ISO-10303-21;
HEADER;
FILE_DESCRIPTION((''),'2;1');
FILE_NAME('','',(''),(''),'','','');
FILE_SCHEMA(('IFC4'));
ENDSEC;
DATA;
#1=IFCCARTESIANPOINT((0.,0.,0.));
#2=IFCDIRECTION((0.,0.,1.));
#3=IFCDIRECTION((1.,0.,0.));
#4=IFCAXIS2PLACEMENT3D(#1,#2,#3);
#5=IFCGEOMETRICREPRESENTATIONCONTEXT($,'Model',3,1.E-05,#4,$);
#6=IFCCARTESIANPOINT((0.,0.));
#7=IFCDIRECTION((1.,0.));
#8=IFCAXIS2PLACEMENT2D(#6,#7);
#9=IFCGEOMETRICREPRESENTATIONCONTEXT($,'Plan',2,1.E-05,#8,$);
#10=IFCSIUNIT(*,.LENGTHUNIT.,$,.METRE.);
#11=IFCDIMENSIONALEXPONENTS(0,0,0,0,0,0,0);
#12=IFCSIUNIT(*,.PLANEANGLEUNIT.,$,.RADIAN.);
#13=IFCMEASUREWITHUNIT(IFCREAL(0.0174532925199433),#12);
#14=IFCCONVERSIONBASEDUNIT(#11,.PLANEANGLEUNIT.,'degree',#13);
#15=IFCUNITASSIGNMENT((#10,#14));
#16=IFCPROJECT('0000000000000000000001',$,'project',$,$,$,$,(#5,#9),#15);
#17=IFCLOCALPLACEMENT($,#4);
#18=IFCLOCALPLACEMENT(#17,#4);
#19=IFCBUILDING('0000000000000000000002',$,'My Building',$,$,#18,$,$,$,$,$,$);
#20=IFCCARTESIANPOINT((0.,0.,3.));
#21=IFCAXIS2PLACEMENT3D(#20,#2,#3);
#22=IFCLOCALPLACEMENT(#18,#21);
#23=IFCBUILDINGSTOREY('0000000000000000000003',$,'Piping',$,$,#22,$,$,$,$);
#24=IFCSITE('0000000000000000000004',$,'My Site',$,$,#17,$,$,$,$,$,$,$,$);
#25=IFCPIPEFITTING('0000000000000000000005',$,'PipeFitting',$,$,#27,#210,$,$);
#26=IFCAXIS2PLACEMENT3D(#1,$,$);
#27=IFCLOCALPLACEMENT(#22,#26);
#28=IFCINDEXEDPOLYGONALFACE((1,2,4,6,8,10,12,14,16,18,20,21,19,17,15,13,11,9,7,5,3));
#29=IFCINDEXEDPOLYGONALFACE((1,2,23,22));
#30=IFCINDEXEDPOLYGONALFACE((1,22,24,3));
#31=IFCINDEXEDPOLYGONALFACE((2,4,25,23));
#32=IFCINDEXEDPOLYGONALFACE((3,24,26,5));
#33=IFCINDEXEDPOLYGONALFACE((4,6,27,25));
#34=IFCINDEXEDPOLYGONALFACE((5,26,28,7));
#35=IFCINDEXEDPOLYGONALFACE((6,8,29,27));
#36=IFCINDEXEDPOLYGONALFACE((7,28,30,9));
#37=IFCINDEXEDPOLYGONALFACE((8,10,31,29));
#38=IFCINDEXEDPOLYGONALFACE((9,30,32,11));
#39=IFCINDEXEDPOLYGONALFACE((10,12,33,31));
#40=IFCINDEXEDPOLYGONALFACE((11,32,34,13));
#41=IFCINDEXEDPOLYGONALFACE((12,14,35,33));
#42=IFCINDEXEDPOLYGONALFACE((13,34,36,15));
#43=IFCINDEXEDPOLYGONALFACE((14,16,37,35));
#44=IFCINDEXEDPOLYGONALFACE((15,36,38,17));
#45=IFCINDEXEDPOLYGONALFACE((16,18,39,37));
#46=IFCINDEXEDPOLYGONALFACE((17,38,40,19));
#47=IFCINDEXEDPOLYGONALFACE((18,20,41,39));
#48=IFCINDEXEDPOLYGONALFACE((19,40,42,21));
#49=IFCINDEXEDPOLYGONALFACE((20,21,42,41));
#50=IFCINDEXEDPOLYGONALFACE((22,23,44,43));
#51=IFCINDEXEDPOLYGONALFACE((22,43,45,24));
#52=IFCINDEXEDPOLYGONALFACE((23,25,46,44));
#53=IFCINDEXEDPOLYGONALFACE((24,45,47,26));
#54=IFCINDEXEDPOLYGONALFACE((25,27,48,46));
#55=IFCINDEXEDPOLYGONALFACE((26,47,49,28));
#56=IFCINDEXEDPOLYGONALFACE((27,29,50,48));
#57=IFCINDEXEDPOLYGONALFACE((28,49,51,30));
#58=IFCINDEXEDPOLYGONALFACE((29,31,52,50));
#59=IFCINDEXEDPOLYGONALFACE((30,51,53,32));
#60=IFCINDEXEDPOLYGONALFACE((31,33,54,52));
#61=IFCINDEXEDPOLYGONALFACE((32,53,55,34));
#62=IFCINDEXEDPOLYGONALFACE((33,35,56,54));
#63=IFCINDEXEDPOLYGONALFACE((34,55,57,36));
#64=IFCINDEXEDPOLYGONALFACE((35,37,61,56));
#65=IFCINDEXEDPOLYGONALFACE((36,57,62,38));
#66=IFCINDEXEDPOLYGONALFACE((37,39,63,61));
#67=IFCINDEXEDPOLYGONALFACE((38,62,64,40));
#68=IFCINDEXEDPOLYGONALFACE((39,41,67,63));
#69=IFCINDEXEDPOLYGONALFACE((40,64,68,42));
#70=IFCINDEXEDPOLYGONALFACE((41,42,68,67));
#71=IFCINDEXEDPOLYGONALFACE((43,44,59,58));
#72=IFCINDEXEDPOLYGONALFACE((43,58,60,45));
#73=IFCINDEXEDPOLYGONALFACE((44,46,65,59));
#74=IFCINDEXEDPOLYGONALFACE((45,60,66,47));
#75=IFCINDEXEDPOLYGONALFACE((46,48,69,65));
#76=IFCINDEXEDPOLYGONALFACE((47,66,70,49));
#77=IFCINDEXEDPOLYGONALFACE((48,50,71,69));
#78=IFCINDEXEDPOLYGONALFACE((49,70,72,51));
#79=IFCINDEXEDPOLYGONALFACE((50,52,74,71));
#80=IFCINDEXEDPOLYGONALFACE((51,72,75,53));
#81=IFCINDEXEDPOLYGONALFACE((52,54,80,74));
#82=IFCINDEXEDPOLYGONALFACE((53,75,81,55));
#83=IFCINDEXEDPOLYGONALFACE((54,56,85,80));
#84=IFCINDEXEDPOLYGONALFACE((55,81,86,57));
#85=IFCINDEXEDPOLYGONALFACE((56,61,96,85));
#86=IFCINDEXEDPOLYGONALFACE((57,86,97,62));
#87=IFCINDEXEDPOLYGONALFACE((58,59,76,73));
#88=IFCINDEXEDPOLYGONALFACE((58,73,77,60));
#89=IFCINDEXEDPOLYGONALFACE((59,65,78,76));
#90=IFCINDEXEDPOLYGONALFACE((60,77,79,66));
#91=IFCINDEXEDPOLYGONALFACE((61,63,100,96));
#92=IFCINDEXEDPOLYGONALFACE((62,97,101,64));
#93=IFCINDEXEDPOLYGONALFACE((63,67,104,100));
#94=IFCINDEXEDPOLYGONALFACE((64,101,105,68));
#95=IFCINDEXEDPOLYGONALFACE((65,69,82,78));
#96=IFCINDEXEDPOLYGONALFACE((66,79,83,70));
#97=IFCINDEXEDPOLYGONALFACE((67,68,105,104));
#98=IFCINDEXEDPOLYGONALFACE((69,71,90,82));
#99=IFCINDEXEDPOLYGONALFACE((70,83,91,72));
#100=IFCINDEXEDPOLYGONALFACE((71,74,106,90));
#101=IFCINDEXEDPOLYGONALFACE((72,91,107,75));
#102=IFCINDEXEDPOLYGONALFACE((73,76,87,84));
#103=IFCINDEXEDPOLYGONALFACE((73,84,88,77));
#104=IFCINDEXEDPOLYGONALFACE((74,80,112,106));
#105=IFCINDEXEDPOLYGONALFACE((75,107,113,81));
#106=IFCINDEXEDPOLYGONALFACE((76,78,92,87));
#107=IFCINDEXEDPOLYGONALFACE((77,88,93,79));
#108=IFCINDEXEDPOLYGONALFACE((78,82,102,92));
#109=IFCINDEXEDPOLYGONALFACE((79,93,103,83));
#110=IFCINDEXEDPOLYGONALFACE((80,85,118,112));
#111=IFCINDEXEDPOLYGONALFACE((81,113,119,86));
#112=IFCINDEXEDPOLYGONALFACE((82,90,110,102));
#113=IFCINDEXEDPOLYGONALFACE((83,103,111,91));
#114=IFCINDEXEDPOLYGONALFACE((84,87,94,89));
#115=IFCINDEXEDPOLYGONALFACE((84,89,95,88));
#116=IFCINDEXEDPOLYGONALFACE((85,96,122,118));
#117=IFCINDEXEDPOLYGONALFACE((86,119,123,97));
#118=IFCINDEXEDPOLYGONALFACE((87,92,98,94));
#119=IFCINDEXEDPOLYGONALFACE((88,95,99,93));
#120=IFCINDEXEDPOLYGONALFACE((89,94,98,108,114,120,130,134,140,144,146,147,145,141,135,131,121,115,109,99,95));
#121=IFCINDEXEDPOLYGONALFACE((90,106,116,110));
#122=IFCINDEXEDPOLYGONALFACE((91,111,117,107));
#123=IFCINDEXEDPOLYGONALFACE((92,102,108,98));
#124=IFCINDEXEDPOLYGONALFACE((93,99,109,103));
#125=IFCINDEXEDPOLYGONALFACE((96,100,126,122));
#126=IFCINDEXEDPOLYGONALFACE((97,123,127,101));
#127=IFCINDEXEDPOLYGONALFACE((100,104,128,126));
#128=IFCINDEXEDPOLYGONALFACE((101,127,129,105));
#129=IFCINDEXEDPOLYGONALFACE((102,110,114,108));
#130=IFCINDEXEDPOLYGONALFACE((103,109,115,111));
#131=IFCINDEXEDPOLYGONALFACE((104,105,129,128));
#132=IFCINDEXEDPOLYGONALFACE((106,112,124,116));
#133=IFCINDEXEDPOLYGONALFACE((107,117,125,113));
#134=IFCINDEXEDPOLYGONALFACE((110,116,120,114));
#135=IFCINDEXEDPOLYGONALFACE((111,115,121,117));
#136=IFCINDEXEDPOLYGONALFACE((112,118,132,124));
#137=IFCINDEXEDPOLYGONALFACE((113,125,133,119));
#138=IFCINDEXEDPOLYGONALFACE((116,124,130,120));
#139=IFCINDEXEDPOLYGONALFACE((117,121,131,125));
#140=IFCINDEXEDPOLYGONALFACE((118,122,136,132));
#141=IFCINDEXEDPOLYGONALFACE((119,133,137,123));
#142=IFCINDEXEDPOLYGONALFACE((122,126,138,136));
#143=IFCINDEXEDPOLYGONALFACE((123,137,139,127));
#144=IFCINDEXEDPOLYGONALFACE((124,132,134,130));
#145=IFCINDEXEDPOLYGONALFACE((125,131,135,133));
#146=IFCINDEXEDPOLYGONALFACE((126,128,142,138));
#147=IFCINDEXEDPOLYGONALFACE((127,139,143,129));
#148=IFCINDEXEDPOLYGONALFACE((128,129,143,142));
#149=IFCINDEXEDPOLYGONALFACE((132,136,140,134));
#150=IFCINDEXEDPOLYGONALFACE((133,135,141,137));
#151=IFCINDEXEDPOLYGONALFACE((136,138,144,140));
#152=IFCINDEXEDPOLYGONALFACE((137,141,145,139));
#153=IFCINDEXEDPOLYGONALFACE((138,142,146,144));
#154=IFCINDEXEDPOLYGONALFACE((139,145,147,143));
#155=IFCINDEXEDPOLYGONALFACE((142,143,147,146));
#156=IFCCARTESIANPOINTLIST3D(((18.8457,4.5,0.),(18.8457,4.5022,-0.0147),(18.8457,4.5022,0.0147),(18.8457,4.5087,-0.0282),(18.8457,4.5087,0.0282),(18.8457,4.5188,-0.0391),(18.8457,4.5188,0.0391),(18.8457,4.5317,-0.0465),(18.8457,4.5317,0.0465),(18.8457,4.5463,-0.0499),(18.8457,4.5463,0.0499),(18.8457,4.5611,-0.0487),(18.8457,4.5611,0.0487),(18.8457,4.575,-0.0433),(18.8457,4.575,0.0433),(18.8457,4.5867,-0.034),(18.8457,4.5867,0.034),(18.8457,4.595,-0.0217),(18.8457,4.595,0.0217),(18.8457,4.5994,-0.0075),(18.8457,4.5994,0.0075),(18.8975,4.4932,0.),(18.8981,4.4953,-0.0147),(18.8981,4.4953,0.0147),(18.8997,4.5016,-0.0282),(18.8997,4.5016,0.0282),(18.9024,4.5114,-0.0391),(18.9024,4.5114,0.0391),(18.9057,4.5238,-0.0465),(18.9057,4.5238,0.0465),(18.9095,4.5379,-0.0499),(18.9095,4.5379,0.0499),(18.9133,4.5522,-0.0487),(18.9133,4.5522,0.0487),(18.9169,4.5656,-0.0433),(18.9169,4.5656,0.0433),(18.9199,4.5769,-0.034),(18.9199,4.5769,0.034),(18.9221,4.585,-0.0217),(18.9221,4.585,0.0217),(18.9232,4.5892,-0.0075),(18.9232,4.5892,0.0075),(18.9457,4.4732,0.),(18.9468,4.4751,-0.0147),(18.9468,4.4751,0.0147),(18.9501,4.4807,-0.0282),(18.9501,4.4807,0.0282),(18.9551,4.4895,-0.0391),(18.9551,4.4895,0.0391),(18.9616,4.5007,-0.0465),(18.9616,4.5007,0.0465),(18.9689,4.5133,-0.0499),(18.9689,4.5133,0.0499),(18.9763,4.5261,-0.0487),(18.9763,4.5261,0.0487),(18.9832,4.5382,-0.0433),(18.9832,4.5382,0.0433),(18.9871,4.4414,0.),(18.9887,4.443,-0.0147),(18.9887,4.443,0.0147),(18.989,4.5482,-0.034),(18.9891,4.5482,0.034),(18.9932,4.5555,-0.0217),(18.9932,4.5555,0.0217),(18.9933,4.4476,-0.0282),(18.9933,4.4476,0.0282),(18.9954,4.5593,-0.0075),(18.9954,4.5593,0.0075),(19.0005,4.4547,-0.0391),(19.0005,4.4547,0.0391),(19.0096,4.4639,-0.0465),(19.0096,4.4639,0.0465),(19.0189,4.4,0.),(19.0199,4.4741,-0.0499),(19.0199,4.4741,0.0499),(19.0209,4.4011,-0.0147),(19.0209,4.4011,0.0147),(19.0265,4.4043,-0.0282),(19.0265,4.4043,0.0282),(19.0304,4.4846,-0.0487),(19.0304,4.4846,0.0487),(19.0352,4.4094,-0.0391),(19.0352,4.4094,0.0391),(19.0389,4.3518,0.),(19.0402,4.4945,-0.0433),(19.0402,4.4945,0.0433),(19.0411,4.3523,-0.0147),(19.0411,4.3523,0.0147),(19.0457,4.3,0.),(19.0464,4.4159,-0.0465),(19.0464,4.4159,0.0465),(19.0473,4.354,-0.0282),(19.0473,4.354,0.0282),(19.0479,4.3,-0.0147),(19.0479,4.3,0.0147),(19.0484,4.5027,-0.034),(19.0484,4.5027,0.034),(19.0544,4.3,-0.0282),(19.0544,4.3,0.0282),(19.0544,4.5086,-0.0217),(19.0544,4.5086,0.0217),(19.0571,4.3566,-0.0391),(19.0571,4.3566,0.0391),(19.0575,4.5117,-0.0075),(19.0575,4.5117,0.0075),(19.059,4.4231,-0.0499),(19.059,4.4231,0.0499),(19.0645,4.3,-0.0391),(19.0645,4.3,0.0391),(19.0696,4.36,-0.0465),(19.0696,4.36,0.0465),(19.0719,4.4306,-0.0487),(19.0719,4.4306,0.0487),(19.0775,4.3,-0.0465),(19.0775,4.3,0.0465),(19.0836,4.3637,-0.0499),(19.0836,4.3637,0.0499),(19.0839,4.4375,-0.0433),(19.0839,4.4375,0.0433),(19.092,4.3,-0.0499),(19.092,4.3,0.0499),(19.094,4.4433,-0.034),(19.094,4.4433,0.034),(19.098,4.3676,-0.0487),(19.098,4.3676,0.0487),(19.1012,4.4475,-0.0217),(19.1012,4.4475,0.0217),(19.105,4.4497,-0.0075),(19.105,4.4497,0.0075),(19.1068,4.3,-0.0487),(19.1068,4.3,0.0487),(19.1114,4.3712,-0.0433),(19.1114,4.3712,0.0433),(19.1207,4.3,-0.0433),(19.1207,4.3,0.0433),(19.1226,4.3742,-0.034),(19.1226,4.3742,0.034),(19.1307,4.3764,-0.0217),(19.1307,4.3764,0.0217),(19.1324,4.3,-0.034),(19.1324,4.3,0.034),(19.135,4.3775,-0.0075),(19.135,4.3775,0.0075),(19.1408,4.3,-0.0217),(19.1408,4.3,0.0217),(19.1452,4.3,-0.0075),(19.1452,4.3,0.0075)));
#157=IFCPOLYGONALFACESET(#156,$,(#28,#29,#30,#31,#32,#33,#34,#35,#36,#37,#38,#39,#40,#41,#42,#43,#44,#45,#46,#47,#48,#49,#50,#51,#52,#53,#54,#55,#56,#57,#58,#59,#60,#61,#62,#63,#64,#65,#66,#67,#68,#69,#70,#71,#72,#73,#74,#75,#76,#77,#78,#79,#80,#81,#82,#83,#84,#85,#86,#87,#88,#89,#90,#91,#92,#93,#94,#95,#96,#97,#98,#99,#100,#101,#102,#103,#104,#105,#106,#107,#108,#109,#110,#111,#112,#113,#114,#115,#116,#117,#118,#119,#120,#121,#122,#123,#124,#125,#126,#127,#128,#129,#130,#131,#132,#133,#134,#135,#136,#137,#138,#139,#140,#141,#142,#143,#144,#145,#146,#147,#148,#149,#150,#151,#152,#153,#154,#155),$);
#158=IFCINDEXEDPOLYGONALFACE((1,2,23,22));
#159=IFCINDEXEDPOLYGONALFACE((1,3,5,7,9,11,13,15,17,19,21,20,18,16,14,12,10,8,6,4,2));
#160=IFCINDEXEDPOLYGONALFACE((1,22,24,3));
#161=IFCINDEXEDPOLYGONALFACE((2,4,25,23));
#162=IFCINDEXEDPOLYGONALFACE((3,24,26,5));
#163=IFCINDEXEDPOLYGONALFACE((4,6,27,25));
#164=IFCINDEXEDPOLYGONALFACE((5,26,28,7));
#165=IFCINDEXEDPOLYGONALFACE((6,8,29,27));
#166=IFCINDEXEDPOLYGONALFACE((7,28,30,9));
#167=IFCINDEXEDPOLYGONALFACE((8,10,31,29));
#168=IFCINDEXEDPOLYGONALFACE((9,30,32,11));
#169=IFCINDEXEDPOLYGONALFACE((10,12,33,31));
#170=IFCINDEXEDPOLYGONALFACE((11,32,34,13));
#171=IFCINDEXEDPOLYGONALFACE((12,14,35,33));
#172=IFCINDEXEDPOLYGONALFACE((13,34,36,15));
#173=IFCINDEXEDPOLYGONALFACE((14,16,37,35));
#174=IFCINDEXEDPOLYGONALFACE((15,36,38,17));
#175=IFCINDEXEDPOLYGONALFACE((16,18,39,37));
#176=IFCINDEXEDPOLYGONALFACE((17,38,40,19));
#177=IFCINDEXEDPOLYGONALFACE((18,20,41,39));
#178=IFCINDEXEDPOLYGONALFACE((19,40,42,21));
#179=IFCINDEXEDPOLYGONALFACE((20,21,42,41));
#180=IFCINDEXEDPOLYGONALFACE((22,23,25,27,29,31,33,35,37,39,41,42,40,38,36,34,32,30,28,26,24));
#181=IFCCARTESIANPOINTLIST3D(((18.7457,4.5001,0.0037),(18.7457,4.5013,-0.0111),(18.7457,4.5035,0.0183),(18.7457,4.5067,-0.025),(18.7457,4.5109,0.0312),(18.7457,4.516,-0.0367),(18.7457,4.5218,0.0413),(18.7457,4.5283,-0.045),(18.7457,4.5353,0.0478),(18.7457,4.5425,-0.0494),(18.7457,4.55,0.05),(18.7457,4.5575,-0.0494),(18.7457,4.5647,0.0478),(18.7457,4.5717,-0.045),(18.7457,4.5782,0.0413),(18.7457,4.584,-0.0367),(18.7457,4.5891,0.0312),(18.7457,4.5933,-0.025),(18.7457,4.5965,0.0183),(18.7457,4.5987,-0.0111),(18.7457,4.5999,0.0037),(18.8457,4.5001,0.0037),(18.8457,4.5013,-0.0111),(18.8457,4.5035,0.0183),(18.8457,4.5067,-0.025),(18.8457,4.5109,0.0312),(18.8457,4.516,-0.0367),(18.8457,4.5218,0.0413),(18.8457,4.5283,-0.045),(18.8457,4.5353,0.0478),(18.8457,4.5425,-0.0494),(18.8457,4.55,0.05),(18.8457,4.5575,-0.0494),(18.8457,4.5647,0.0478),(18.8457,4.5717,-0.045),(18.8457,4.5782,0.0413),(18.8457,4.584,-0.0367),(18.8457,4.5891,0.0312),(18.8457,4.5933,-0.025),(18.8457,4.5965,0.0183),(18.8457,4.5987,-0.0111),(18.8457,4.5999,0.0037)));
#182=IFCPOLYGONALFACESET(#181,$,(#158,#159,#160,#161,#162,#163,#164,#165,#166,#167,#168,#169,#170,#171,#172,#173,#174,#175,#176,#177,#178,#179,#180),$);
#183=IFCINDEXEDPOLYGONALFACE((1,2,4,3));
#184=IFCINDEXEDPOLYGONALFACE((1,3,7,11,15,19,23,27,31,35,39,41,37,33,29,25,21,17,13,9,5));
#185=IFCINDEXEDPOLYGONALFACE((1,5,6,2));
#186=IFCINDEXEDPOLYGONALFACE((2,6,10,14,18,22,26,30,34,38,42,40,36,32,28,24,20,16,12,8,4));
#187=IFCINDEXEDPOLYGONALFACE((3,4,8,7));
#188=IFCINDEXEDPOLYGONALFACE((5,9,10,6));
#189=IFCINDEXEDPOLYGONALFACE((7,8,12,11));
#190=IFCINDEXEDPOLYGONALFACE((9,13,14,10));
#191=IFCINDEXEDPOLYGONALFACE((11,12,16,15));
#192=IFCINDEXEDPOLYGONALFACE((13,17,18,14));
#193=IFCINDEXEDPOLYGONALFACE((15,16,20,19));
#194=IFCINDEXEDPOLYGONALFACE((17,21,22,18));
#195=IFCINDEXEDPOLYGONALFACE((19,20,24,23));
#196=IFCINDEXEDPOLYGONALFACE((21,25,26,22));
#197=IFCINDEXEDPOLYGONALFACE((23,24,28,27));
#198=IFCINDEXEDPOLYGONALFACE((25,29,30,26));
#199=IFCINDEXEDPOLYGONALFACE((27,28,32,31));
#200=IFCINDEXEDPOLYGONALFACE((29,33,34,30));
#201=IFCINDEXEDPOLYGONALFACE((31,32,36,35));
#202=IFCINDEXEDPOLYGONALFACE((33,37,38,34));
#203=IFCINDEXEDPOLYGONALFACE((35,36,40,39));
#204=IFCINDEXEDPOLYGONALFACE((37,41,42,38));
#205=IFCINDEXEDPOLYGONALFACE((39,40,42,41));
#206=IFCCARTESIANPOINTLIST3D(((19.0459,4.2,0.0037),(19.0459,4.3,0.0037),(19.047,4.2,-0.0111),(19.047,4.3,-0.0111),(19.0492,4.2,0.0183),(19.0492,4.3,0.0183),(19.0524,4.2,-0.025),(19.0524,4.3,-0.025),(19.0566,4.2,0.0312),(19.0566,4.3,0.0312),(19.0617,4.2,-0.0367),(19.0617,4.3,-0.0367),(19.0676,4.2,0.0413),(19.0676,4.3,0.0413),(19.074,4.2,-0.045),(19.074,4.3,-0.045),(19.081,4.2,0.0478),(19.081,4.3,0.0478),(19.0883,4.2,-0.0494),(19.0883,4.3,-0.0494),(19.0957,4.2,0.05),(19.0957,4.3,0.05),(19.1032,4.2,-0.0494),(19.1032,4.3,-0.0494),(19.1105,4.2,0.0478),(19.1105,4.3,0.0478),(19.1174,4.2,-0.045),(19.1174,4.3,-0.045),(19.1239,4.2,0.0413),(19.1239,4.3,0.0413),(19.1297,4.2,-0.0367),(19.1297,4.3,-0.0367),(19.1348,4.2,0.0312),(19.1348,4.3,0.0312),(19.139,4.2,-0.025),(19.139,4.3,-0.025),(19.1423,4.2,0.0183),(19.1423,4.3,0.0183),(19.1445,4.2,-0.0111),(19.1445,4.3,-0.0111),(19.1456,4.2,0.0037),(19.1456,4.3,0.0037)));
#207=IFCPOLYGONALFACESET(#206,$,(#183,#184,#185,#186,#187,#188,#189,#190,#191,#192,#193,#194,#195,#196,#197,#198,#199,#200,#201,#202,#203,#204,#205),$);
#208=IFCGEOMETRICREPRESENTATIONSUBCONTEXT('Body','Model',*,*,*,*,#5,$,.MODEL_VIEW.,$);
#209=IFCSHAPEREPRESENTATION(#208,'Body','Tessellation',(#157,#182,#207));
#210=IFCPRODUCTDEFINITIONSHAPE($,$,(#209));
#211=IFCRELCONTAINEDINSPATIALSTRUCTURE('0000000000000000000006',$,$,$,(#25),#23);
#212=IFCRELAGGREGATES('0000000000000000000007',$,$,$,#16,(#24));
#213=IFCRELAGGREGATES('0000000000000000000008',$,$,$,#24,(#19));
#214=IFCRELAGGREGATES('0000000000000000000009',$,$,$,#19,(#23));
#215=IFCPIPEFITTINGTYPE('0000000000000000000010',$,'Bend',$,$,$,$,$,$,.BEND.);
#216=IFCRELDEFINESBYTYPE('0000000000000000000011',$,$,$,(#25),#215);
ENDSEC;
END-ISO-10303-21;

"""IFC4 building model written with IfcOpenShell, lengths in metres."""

from ifc_helpers import new_model, entity, si_unit, converted_unit, frame, origin_with_axes, origin_2d_with_axis, place, context, subcontext, project, spatial, circle, extrude, source, transform, mapped, type_object, type_shapes, element, save


model = new_model("IFC4")

# Units and contexts
model_context = context("Model", 3, precision=1e-05, world=origin_with_axes())
plan_context = context("Plan", 2, precision=1e-05, world=origin_2d_with_axis())
body_context = subcontext(model_context, "Body", "Model", "MODEL_VIEW")
ifc_project = project(units=[si_unit("LENGTHUNIT", "METRE"), converted_unit("PLANEANGLEUNIT", "degree", entity("IfcReal", 0.0174532925199433), si_unit("PLANEANGLEUNIT", "RADIAN"), dimensions=[0, 0, 0, 0, 0, 0, 0])], contexts=[model_context, plan_context])

# Site, building, storey
site_placement = place(None, origin_with_axes())
site = spatial("IfcSite", under=ifc_project, at=site_placement, Name="My Site")
building_placement = place(site_placement, origin_with_axes())
building = spatial("IfcBuilding", under=site, at=building_placement, Name="My Building")
storey_placement = place(building_placement, frame((0.0, 0.0, 3.0), z_axis=(0.0, 0.0, 1.0), x_axis=(1.0, 0.0, 0.0)))
storey = spatial("IfcBuildingStorey", under=building, at=storey_placement, Name="Piping")

# Pipe fitting
pipe_fitting_type = type_object("IfcPipeFittingType", Name="Bend", PredefinedType="BEND")
shared_shape = source(origin_with_axes(), body_context, "Body", "SolidModel", [
    entity("IfcSweptDiskSolid", entity("IfcIndexedPolyCurve", entity("IfcCartesianPointList3D", [[0.0, 0.0, -0.1], [0.0, -0.0732, -0.2768], [0.0, -0.25, -0.35]]), [entity("IfcArcIndex", [1, 2, 3])]), 0.05),
    extrude(circle(Radius=0.05), origin_with_axes(), (0.0, 0.0, -1.0), 0.1),
    extrude(circle(Radius=0.05), frame((0.0, -0.25, -0.35), z_axis=(0.0, -1.0, 0.0), x_axis=(1.0, 0.0, 0.0)), (0.0, 0.0, 1.0), 0.1),
])
type_shapes(pipe_fitting_type, [shared_shape])
for number, where, z_axis, x_axis, name in (
    (1, (18.7457, 4.55, 0.0), (-1.0, 0.0, 0.0), (0.0, 0.0, 1.0), "PipeFitting"),
):
    element("IfcPipeFitting", number, at=place(storey_placement, frame(where, z_axis=z_axis, x_axis=x_axis)), inside=storey, type_object=pipe_fitting_type, Name=name, context=body_context, shape_type="MappedRepresentation", body=[
        mapped(shared_shape, transform((0.0, 0.0, 0.0), x_axis=(1.0, 0.0, 0.0), y_axis=(0.0, 1.0, 0.0), z_axis=(0.0, 0.0, 1.0), scale=1.0)),
    ])

save(model, "model.ifc")
